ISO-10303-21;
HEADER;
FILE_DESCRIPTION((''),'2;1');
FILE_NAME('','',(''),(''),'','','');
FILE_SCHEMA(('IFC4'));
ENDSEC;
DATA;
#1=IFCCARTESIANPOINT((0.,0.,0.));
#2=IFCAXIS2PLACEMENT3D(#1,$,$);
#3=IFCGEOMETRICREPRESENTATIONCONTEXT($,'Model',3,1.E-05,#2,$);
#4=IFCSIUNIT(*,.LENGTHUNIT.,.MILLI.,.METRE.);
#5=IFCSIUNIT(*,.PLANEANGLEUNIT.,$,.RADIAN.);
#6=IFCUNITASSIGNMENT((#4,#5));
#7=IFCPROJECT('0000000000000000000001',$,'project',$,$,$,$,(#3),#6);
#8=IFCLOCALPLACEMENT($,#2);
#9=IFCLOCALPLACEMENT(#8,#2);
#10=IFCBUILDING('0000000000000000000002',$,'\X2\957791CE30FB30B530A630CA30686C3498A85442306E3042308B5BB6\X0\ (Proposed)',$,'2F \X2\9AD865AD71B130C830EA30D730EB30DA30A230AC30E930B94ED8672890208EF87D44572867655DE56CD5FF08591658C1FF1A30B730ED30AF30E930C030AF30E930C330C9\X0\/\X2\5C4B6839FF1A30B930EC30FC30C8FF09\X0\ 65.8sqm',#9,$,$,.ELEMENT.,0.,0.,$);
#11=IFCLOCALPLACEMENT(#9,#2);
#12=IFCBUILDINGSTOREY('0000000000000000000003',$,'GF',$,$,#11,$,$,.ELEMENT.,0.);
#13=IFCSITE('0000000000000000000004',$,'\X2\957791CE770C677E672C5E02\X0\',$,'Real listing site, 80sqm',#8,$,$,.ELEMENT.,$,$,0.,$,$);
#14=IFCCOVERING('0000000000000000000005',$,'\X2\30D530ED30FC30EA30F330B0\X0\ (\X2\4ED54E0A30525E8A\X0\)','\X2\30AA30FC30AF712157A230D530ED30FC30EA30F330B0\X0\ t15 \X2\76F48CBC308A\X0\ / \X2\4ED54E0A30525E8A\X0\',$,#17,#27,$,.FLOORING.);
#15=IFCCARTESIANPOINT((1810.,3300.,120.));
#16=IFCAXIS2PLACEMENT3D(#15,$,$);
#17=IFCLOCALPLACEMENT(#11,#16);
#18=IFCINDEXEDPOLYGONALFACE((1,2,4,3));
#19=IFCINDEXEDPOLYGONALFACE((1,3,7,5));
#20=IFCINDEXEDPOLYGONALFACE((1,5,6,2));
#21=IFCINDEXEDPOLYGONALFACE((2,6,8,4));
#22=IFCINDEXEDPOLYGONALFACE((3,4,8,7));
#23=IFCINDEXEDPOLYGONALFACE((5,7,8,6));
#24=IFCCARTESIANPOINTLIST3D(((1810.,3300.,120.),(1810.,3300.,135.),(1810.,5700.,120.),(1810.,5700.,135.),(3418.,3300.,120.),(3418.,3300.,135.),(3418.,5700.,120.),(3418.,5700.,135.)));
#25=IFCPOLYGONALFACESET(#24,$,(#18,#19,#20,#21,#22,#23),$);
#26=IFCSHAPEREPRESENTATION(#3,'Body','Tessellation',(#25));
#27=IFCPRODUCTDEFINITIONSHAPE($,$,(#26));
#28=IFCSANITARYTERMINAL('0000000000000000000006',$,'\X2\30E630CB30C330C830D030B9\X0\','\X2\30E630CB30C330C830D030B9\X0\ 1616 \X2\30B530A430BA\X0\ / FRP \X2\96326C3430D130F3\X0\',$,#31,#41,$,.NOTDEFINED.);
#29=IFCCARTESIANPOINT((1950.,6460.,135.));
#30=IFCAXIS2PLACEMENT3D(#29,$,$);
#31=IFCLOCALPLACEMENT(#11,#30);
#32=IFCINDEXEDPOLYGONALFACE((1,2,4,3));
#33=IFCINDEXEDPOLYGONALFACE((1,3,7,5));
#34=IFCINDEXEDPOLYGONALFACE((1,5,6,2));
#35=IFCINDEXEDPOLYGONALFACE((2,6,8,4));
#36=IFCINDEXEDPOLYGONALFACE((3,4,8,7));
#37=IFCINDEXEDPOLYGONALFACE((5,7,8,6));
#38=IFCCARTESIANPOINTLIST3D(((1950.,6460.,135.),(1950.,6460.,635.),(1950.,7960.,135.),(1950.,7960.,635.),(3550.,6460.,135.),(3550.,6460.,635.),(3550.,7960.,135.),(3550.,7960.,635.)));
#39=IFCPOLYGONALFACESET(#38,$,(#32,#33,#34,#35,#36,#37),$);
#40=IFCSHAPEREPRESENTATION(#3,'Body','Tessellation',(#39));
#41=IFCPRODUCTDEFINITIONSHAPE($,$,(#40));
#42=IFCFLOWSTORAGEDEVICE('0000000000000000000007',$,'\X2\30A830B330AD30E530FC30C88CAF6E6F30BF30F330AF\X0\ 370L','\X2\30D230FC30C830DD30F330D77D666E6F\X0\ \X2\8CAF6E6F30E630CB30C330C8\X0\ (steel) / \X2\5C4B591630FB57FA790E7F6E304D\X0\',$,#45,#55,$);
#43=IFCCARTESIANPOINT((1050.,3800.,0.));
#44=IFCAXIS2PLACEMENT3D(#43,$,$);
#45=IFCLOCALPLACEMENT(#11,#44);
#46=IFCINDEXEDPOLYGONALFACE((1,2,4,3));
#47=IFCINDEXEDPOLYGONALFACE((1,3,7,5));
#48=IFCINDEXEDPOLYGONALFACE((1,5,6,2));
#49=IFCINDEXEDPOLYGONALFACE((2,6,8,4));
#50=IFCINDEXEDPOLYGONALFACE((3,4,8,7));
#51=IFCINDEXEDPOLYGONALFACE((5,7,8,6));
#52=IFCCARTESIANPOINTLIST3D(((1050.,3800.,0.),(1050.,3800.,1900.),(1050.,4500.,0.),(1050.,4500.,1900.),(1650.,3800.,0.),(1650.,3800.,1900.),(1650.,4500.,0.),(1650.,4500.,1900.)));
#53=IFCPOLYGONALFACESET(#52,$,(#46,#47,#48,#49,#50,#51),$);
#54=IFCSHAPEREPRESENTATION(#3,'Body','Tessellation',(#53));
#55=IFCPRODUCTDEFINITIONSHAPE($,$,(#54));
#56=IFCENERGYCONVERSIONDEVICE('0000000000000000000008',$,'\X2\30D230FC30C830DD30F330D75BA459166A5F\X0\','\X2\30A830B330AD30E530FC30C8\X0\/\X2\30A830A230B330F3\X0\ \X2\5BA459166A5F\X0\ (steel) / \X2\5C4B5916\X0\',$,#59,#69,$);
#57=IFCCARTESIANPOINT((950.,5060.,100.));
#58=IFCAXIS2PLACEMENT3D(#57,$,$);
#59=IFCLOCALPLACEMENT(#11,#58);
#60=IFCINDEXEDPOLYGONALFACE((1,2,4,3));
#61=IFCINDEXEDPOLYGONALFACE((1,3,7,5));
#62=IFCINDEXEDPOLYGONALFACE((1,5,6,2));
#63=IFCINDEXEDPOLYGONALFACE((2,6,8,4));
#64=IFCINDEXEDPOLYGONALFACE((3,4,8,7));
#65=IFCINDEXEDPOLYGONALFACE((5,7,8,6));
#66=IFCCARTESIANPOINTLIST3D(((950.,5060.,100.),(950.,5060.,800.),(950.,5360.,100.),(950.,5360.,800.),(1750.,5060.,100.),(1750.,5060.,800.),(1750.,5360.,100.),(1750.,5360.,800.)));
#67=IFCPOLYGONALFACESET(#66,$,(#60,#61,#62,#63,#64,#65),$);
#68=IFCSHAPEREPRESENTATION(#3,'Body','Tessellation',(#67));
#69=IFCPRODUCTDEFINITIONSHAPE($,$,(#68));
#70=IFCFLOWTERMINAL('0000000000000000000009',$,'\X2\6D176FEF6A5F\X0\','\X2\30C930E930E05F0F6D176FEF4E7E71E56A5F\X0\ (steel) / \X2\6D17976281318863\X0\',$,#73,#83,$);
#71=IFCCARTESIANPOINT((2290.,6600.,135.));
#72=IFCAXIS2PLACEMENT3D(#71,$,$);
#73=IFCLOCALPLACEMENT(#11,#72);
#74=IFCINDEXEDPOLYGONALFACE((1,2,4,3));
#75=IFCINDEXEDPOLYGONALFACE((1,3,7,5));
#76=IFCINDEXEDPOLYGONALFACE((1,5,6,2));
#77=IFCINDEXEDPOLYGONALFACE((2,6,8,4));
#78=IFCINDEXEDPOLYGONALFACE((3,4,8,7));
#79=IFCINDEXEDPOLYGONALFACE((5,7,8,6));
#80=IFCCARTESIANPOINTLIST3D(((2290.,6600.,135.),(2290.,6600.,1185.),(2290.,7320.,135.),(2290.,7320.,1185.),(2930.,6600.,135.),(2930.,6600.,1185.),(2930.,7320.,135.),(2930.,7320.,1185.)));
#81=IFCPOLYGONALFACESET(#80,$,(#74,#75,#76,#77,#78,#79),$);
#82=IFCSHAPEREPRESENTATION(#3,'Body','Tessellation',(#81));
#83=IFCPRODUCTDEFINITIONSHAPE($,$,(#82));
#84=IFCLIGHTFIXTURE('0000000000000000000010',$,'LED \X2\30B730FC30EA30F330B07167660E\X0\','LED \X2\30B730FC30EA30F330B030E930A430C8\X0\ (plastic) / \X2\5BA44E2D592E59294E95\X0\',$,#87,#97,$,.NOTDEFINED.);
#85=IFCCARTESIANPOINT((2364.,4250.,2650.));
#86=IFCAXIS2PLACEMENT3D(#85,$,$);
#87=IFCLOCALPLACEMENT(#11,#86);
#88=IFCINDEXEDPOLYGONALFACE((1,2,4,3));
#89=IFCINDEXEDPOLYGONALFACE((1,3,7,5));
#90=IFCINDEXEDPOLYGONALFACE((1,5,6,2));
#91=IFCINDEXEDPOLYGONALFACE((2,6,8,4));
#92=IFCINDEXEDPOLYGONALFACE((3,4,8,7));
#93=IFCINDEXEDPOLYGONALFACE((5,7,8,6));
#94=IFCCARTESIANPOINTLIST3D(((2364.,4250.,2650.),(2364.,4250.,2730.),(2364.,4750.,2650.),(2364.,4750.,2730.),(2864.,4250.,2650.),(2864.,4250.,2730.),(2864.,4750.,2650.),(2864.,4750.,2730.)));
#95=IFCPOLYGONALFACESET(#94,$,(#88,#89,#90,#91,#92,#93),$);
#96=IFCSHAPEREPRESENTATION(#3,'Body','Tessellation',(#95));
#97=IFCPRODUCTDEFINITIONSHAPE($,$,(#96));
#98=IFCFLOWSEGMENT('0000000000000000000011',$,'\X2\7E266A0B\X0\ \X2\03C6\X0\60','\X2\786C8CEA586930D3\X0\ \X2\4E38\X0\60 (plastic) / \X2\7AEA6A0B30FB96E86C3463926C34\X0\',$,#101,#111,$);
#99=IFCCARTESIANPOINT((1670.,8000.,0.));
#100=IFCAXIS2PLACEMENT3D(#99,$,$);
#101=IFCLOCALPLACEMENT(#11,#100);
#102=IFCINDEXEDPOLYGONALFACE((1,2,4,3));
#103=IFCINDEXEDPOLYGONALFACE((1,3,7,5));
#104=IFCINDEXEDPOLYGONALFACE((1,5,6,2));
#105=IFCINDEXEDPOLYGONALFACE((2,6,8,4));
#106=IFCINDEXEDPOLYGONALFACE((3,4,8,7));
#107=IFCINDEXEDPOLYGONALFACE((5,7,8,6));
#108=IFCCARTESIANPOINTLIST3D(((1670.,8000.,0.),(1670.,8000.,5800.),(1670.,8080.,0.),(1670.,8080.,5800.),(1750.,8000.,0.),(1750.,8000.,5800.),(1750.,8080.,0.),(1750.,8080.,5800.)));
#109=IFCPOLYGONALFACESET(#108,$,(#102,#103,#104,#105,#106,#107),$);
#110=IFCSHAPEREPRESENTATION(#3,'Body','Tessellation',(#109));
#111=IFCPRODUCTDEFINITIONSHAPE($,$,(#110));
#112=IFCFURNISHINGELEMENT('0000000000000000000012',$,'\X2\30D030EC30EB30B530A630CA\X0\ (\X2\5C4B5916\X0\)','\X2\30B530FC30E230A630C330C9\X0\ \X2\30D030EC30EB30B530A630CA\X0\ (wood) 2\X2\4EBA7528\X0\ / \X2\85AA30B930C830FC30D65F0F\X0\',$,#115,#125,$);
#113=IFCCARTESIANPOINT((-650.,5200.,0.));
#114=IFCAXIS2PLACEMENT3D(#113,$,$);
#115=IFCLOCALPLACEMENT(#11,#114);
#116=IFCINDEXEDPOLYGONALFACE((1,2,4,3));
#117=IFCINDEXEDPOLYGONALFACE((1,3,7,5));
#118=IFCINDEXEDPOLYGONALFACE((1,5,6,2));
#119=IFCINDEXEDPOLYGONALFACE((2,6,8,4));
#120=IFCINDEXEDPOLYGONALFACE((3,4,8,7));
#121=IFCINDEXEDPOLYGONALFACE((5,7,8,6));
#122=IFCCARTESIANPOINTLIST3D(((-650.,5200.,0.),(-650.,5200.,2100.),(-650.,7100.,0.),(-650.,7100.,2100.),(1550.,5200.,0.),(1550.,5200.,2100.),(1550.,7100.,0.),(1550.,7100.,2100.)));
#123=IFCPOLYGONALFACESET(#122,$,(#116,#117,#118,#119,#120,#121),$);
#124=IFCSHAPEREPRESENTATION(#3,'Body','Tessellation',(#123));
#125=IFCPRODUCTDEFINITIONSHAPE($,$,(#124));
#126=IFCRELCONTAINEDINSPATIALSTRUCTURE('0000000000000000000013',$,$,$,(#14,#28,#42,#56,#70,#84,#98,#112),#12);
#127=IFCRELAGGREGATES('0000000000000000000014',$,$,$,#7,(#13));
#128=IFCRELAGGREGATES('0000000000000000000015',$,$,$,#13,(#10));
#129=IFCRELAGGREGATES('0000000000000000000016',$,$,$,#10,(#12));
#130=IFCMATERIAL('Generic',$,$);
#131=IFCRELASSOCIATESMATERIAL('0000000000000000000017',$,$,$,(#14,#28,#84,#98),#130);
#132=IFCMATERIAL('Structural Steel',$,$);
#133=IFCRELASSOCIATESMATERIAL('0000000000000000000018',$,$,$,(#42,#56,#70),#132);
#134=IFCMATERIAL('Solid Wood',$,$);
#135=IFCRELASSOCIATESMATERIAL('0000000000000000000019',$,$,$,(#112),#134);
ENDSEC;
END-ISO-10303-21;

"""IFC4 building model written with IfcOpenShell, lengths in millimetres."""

from ifc_helpers import new_model, si_unit, frame, frame_2d, origin, place, context, project, spatial, rectangle, extrude, material, element, save


model = new_model("IFC4")

# Units and contexts
model_context = context("Model", 3, precision=1e-05, world=origin())
ifc_project = project(units=[si_unit("LENGTHUNIT", "METRE", prefix="MILLI"), si_unit("PLANEANGLEUNIT", "RADIAN")], contexts=[model_context])

# Site, building, storey
site_placement = place(None, origin())
site = spatial("IfcSite", under=ifc_project, at=site_placement, Name="長野県松本市", ObjectType="Real listing site, 80sqm", CompositionType="ELEMENT", RefElevation=0.0)
building_placement = place(site_placement, origin())
building = spatial("IfcBuilding", under=site, at=building_placement, Name="長野・サウナと水風呂のある家 (Proposed)", ObjectType="2F 高断熱トリプルペアガラス付木造軸組在来工法（外壁：シロクラダクラッド/屋根：スレート） 65.8sqm", CompositionType="ELEMENT", ElevationOfRefHeight=0.0, ElevationOfTerrain=0.0)
storey_placement = place(building_placement, origin())
storey = spatial("IfcBuildingStorey", under=building, at=storey_placement, Name="GF", CompositionType="ELEMENT", Elevation=0.0)

# Shared definitions
ifc_material_1 = material(Name="Solid Wood")

# Covering
ifc_material_2 = material(Name="Generic")
covering_1_placement = place(storey_placement, frame((1810.0, 3300.0, 120.0)))
element("IfcCovering", 1, at=covering_1_placement, inside=storey, material=ifc_material_2, Name="フローリング (仕上げ床)", Description="オーク無垢フローリング t15 直貼り / 仕上げ床", PredefinedType="FLOORING", context=model_context, shape_type="SweptSolid", body=[
    extrude(rectangle(XDim=1608.0, YDim=2400.0, at=frame_2d((804.0, 1200.0))), frame((1810.0, 3300.0, 120.0)), (0.0, 0.0, 1.0), 15.0),
])

# Sanitary terminal
sanitary_terminal_placement = place(storey_placement, frame((1950.0, 6460.0, 135.0)))
element("IfcSanitaryTerminal", 2, at=sanitary_terminal_placement, inside=storey, material=ifc_material_2, Name="ユニットバス", Description="ユニットバス 1616 サイズ / FRP 防水パン", PredefinedType="NOTDEFINED", context=model_context, shape_type="SweptSolid", body=[
    extrude(rectangle(XDim=1600.0, YDim=1500.0, at=frame_2d((800.0, 750.0))), frame((1950.0, 6460.0, 135.0)), (0.0, 0.0, 1.0), 500.0),
])

# Flow storage device
ifc_material_3 = material(Name="Structural Steel")
flow_storage_device_placement = place(storey_placement, frame((1050.0, 3800.0, 0.0)))
element("IfcFlowStorageDevice", 3, at=flow_storage_device_placement, inside=storey, material=ifc_material_3, Name="エコキュート貯湯タンク 370L", Description="ヒートポンプ給湯 貯湯ユニット (steel) / 屋外・基礎置き", context=model_context, shape_type="SweptSolid", body=[
    extrude(rectangle(XDim=600.0, YDim=700.0, at=frame_2d((300.0, 350.0))), frame((1050.0, 3800.0, 0.0)), (0.0, 0.0, 1.0), 1900.0),
])

# Energy conversion device
energy_conversion_device_placement = place(storey_placement, frame((950.0, 5060.0, 100.0)))
element("IfcEnergyConversionDevice", 4, at=energy_conversion_device_placement, inside=storey, material=ifc_material_3, Name="ヒートポンプ室外機", Description="エコキュート/エアコン 室外機 (steel) / 屋外", context=model_context, shape_type="SweptSolid", body=[
    extrude(rectangle(XDim=800.0, YDim=300.0, at=frame_2d((400.0, 150.0))), frame((950.0, 5060.0, 100.0)), (0.0, 0.0, 1.0), 700.0),
])

# Flow terminal
flow_terminal_placement = place(storey_placement, frame((2290.0, 6600.0, 135.0)))
element("IfcFlowTerminal", 5, at=flow_terminal_placement, inside=storey, material=ifc_material_3, Name="洗濯機", Description="ドラム式洗濯乾燥機 (steel) / 洗面脱衣", context=model_context, shape_type="SweptSolid", body=[
    extrude(rectangle(XDim=640.0, YDim=720.0, at=frame_2d((320.0, 360.0))), frame((2290.0, 6600.0, 135.0)), (0.0, 0.0, 1.0), 1050.0),
])

# Light fixture
light_fixture_placement = place(storey_placement, frame((2364.0, 4250.0, 2650.0)))
element("IfcLightFixture", 6, at=light_fixture_placement, inside=storey, material=ifc_material_2, Name="LED シーリング照明", Description="LED シーリングライト (plastic) / 室中央天井", PredefinedType="NOTDEFINED", context=model_context, shape_type="SweptSolid", body=[
    extrude(rectangle(XDim=500.0, YDim=500.0, at=frame_2d((250.0, 250.0))), frame((2364.0, 4250.0, 2650.0)), (0.0, 0.0, 1.0), 80.0),
])

# Flow segment
flow_segment_placement = place(storey_placement, frame((1670.0, 8000.0, 0.0)))
element("IfcFlowSegment", 7, at=flow_segment_placement, inside=storey, material=ifc_material_2, Name="縦樋 φ60", Description="硬質塩ビ 丸60 (plastic) / 竪樋・雨水排水", context=model_context, shape_type="SweptSolid", body=[
    extrude(rectangle(XDim=80.0, YDim=80.0, at=frame_2d((40.0, 40.0))), frame((1670.0, 8000.0, 0.0)), (0.0, 0.0, 1.0), 5800.0),
])

# Furnishing element
furnishing_placement = place(storey_placement, frame((-650.0, 5200.0, 0.0)))
element("IfcFurnishingElement", 8, at=furnishing_placement, inside=storey, material=ifc_material_1, Name="バレルサウナ (屋外)", Description="サーモウッド バレルサウナ (wood) 2人用 / 薪ストーブ式", context=model_context, shape_type="SweptSolid", body=[
    extrude(rectangle(XDim=2200.0, YDim=1900.0, at=frame_2d((1100.0, 950.0))), frame((-650.0, 5200.0, 0.0)), (0.0, 0.0, 1.0), 2100.0),
])

save(model, "model.ifc")
